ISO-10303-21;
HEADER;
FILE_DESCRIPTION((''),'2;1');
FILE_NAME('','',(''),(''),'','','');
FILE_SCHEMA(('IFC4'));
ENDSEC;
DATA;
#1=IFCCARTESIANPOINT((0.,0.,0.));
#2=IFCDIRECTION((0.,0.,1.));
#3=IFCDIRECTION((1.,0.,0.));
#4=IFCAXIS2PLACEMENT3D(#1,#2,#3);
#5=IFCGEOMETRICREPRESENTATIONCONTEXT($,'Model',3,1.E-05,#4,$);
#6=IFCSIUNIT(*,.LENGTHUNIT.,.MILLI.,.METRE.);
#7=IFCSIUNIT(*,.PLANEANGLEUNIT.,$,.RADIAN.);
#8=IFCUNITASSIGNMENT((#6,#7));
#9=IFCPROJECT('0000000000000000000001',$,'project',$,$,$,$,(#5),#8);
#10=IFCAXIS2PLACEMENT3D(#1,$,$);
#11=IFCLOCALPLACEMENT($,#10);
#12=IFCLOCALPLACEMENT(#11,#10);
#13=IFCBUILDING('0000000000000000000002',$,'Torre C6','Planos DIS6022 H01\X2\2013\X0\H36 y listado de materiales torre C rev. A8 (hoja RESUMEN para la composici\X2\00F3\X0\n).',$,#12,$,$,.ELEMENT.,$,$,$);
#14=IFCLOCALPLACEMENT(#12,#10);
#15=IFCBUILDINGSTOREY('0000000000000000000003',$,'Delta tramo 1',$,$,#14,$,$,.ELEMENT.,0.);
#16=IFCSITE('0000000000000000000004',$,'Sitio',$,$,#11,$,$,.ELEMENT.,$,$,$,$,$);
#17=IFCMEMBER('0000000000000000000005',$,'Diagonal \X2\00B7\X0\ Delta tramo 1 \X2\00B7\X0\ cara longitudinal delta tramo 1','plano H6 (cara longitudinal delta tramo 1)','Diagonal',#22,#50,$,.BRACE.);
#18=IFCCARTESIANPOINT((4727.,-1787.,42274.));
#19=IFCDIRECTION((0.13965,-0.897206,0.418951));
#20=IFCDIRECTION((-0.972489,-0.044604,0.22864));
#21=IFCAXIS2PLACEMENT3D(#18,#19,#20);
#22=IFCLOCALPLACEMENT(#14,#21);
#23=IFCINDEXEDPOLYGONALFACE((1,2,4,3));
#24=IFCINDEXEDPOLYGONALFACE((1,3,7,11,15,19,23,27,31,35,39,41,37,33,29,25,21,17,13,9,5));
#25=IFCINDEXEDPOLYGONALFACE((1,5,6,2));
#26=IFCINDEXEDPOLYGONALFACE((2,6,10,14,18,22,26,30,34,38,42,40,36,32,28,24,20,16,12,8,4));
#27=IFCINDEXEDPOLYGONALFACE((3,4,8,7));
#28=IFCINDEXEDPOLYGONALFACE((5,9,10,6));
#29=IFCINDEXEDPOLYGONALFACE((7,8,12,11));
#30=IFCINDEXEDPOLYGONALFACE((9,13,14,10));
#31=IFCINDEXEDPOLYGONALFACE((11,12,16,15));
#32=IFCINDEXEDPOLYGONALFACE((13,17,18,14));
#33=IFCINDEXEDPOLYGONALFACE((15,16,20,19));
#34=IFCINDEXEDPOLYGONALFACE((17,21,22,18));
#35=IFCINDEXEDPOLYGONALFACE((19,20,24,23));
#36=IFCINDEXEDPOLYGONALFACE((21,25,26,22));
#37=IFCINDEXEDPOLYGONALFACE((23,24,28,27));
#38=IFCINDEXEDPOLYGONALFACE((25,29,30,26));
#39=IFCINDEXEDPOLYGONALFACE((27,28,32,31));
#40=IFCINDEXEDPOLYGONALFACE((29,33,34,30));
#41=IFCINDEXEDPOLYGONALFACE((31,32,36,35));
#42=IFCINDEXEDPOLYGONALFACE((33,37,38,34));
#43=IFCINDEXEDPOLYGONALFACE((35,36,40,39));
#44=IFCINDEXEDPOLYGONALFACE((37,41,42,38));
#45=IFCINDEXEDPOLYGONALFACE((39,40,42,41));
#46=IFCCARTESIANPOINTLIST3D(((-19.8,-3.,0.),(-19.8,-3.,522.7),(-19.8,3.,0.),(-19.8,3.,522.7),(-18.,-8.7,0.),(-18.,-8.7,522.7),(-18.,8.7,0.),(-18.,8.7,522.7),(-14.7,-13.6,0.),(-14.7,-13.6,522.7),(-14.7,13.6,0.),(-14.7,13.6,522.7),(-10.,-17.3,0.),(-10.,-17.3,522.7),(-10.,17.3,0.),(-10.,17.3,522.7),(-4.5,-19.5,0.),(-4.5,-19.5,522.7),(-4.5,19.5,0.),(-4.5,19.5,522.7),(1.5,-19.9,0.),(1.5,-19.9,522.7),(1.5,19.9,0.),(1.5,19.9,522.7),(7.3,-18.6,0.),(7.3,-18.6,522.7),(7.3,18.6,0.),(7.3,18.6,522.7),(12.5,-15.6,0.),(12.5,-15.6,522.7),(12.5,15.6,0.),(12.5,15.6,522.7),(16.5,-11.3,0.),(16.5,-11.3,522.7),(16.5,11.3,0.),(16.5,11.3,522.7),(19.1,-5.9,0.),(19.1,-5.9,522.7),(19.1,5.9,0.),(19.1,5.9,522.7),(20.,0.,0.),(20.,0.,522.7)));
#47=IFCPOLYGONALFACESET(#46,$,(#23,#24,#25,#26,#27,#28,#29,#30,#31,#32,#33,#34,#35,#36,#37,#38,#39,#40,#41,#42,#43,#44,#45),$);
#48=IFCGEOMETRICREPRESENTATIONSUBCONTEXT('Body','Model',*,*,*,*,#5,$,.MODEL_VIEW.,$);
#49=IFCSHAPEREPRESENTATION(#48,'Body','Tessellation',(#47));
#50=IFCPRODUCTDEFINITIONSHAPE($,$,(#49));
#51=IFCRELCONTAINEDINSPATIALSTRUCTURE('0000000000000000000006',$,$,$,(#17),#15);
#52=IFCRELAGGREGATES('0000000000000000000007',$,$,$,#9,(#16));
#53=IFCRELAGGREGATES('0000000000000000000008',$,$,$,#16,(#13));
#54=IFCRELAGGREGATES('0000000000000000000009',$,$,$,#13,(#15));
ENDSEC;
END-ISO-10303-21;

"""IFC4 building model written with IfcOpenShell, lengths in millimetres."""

from ifc_helpers import new_model, si_unit, frame, origin, origin_with_axes, place, context, subcontext, project, spatial, circle, extrude, element, save


model = new_model("IFC4")

# Units and contexts
model_context = context("Model", 3, precision=1e-05, world=origin_with_axes())
body_context = subcontext(model_context, "Body", "Model", "MODEL_VIEW")
ifc_project = project(units=[si_unit("LENGTHUNIT", "METRE", prefix="MILLI"), si_unit("PLANEANGLEUNIT", "RADIAN")], contexts=[model_context])

# Site, building, storey
site_placement = place(None, origin())
site = spatial("IfcSite", under=ifc_project, at=site_placement, Name="Sitio", CompositionType="ELEMENT")
building_placement = place(site_placement, origin())
building = spatial("IfcBuilding", under=site, at=building_placement, Name="Torre C6", Description="Planos DIS6022 H01–H36 y listado de materiales torre C rev. A8 (hoja RESUMEN para la composición).", CompositionType="ELEMENT")
storey_placement = place(building_placement, origin())
storey = spatial("IfcBuildingStorey", under=building, at=storey_placement, Name="Delta tramo 1", CompositionType="ELEMENT", Elevation=0.0)

# Member
member_1_placement = place(storey_placement, frame((4727.0, -1787.0, 42274.0), z_axis=(0.13965, -0.897206, 0.418951), x_axis=(-0.972489, -0.044604, 0.22864)))
element("IfcMember", 1, at=member_1_placement, inside=storey, Name="Diagonal · Delta tramo 1 · cara longitudinal delta tramo 1", Description="plano H6 (cara longitudinal delta tramo 1)", ObjectType="Diagonal", PredefinedType="BRACE", context=body_context, shape_type="SweptSolid", body=[
    extrude(circle(Radius=20.0), None, (0.0, 0.0, 1.0), 522.7),
])

save(model, "model.ifc")
